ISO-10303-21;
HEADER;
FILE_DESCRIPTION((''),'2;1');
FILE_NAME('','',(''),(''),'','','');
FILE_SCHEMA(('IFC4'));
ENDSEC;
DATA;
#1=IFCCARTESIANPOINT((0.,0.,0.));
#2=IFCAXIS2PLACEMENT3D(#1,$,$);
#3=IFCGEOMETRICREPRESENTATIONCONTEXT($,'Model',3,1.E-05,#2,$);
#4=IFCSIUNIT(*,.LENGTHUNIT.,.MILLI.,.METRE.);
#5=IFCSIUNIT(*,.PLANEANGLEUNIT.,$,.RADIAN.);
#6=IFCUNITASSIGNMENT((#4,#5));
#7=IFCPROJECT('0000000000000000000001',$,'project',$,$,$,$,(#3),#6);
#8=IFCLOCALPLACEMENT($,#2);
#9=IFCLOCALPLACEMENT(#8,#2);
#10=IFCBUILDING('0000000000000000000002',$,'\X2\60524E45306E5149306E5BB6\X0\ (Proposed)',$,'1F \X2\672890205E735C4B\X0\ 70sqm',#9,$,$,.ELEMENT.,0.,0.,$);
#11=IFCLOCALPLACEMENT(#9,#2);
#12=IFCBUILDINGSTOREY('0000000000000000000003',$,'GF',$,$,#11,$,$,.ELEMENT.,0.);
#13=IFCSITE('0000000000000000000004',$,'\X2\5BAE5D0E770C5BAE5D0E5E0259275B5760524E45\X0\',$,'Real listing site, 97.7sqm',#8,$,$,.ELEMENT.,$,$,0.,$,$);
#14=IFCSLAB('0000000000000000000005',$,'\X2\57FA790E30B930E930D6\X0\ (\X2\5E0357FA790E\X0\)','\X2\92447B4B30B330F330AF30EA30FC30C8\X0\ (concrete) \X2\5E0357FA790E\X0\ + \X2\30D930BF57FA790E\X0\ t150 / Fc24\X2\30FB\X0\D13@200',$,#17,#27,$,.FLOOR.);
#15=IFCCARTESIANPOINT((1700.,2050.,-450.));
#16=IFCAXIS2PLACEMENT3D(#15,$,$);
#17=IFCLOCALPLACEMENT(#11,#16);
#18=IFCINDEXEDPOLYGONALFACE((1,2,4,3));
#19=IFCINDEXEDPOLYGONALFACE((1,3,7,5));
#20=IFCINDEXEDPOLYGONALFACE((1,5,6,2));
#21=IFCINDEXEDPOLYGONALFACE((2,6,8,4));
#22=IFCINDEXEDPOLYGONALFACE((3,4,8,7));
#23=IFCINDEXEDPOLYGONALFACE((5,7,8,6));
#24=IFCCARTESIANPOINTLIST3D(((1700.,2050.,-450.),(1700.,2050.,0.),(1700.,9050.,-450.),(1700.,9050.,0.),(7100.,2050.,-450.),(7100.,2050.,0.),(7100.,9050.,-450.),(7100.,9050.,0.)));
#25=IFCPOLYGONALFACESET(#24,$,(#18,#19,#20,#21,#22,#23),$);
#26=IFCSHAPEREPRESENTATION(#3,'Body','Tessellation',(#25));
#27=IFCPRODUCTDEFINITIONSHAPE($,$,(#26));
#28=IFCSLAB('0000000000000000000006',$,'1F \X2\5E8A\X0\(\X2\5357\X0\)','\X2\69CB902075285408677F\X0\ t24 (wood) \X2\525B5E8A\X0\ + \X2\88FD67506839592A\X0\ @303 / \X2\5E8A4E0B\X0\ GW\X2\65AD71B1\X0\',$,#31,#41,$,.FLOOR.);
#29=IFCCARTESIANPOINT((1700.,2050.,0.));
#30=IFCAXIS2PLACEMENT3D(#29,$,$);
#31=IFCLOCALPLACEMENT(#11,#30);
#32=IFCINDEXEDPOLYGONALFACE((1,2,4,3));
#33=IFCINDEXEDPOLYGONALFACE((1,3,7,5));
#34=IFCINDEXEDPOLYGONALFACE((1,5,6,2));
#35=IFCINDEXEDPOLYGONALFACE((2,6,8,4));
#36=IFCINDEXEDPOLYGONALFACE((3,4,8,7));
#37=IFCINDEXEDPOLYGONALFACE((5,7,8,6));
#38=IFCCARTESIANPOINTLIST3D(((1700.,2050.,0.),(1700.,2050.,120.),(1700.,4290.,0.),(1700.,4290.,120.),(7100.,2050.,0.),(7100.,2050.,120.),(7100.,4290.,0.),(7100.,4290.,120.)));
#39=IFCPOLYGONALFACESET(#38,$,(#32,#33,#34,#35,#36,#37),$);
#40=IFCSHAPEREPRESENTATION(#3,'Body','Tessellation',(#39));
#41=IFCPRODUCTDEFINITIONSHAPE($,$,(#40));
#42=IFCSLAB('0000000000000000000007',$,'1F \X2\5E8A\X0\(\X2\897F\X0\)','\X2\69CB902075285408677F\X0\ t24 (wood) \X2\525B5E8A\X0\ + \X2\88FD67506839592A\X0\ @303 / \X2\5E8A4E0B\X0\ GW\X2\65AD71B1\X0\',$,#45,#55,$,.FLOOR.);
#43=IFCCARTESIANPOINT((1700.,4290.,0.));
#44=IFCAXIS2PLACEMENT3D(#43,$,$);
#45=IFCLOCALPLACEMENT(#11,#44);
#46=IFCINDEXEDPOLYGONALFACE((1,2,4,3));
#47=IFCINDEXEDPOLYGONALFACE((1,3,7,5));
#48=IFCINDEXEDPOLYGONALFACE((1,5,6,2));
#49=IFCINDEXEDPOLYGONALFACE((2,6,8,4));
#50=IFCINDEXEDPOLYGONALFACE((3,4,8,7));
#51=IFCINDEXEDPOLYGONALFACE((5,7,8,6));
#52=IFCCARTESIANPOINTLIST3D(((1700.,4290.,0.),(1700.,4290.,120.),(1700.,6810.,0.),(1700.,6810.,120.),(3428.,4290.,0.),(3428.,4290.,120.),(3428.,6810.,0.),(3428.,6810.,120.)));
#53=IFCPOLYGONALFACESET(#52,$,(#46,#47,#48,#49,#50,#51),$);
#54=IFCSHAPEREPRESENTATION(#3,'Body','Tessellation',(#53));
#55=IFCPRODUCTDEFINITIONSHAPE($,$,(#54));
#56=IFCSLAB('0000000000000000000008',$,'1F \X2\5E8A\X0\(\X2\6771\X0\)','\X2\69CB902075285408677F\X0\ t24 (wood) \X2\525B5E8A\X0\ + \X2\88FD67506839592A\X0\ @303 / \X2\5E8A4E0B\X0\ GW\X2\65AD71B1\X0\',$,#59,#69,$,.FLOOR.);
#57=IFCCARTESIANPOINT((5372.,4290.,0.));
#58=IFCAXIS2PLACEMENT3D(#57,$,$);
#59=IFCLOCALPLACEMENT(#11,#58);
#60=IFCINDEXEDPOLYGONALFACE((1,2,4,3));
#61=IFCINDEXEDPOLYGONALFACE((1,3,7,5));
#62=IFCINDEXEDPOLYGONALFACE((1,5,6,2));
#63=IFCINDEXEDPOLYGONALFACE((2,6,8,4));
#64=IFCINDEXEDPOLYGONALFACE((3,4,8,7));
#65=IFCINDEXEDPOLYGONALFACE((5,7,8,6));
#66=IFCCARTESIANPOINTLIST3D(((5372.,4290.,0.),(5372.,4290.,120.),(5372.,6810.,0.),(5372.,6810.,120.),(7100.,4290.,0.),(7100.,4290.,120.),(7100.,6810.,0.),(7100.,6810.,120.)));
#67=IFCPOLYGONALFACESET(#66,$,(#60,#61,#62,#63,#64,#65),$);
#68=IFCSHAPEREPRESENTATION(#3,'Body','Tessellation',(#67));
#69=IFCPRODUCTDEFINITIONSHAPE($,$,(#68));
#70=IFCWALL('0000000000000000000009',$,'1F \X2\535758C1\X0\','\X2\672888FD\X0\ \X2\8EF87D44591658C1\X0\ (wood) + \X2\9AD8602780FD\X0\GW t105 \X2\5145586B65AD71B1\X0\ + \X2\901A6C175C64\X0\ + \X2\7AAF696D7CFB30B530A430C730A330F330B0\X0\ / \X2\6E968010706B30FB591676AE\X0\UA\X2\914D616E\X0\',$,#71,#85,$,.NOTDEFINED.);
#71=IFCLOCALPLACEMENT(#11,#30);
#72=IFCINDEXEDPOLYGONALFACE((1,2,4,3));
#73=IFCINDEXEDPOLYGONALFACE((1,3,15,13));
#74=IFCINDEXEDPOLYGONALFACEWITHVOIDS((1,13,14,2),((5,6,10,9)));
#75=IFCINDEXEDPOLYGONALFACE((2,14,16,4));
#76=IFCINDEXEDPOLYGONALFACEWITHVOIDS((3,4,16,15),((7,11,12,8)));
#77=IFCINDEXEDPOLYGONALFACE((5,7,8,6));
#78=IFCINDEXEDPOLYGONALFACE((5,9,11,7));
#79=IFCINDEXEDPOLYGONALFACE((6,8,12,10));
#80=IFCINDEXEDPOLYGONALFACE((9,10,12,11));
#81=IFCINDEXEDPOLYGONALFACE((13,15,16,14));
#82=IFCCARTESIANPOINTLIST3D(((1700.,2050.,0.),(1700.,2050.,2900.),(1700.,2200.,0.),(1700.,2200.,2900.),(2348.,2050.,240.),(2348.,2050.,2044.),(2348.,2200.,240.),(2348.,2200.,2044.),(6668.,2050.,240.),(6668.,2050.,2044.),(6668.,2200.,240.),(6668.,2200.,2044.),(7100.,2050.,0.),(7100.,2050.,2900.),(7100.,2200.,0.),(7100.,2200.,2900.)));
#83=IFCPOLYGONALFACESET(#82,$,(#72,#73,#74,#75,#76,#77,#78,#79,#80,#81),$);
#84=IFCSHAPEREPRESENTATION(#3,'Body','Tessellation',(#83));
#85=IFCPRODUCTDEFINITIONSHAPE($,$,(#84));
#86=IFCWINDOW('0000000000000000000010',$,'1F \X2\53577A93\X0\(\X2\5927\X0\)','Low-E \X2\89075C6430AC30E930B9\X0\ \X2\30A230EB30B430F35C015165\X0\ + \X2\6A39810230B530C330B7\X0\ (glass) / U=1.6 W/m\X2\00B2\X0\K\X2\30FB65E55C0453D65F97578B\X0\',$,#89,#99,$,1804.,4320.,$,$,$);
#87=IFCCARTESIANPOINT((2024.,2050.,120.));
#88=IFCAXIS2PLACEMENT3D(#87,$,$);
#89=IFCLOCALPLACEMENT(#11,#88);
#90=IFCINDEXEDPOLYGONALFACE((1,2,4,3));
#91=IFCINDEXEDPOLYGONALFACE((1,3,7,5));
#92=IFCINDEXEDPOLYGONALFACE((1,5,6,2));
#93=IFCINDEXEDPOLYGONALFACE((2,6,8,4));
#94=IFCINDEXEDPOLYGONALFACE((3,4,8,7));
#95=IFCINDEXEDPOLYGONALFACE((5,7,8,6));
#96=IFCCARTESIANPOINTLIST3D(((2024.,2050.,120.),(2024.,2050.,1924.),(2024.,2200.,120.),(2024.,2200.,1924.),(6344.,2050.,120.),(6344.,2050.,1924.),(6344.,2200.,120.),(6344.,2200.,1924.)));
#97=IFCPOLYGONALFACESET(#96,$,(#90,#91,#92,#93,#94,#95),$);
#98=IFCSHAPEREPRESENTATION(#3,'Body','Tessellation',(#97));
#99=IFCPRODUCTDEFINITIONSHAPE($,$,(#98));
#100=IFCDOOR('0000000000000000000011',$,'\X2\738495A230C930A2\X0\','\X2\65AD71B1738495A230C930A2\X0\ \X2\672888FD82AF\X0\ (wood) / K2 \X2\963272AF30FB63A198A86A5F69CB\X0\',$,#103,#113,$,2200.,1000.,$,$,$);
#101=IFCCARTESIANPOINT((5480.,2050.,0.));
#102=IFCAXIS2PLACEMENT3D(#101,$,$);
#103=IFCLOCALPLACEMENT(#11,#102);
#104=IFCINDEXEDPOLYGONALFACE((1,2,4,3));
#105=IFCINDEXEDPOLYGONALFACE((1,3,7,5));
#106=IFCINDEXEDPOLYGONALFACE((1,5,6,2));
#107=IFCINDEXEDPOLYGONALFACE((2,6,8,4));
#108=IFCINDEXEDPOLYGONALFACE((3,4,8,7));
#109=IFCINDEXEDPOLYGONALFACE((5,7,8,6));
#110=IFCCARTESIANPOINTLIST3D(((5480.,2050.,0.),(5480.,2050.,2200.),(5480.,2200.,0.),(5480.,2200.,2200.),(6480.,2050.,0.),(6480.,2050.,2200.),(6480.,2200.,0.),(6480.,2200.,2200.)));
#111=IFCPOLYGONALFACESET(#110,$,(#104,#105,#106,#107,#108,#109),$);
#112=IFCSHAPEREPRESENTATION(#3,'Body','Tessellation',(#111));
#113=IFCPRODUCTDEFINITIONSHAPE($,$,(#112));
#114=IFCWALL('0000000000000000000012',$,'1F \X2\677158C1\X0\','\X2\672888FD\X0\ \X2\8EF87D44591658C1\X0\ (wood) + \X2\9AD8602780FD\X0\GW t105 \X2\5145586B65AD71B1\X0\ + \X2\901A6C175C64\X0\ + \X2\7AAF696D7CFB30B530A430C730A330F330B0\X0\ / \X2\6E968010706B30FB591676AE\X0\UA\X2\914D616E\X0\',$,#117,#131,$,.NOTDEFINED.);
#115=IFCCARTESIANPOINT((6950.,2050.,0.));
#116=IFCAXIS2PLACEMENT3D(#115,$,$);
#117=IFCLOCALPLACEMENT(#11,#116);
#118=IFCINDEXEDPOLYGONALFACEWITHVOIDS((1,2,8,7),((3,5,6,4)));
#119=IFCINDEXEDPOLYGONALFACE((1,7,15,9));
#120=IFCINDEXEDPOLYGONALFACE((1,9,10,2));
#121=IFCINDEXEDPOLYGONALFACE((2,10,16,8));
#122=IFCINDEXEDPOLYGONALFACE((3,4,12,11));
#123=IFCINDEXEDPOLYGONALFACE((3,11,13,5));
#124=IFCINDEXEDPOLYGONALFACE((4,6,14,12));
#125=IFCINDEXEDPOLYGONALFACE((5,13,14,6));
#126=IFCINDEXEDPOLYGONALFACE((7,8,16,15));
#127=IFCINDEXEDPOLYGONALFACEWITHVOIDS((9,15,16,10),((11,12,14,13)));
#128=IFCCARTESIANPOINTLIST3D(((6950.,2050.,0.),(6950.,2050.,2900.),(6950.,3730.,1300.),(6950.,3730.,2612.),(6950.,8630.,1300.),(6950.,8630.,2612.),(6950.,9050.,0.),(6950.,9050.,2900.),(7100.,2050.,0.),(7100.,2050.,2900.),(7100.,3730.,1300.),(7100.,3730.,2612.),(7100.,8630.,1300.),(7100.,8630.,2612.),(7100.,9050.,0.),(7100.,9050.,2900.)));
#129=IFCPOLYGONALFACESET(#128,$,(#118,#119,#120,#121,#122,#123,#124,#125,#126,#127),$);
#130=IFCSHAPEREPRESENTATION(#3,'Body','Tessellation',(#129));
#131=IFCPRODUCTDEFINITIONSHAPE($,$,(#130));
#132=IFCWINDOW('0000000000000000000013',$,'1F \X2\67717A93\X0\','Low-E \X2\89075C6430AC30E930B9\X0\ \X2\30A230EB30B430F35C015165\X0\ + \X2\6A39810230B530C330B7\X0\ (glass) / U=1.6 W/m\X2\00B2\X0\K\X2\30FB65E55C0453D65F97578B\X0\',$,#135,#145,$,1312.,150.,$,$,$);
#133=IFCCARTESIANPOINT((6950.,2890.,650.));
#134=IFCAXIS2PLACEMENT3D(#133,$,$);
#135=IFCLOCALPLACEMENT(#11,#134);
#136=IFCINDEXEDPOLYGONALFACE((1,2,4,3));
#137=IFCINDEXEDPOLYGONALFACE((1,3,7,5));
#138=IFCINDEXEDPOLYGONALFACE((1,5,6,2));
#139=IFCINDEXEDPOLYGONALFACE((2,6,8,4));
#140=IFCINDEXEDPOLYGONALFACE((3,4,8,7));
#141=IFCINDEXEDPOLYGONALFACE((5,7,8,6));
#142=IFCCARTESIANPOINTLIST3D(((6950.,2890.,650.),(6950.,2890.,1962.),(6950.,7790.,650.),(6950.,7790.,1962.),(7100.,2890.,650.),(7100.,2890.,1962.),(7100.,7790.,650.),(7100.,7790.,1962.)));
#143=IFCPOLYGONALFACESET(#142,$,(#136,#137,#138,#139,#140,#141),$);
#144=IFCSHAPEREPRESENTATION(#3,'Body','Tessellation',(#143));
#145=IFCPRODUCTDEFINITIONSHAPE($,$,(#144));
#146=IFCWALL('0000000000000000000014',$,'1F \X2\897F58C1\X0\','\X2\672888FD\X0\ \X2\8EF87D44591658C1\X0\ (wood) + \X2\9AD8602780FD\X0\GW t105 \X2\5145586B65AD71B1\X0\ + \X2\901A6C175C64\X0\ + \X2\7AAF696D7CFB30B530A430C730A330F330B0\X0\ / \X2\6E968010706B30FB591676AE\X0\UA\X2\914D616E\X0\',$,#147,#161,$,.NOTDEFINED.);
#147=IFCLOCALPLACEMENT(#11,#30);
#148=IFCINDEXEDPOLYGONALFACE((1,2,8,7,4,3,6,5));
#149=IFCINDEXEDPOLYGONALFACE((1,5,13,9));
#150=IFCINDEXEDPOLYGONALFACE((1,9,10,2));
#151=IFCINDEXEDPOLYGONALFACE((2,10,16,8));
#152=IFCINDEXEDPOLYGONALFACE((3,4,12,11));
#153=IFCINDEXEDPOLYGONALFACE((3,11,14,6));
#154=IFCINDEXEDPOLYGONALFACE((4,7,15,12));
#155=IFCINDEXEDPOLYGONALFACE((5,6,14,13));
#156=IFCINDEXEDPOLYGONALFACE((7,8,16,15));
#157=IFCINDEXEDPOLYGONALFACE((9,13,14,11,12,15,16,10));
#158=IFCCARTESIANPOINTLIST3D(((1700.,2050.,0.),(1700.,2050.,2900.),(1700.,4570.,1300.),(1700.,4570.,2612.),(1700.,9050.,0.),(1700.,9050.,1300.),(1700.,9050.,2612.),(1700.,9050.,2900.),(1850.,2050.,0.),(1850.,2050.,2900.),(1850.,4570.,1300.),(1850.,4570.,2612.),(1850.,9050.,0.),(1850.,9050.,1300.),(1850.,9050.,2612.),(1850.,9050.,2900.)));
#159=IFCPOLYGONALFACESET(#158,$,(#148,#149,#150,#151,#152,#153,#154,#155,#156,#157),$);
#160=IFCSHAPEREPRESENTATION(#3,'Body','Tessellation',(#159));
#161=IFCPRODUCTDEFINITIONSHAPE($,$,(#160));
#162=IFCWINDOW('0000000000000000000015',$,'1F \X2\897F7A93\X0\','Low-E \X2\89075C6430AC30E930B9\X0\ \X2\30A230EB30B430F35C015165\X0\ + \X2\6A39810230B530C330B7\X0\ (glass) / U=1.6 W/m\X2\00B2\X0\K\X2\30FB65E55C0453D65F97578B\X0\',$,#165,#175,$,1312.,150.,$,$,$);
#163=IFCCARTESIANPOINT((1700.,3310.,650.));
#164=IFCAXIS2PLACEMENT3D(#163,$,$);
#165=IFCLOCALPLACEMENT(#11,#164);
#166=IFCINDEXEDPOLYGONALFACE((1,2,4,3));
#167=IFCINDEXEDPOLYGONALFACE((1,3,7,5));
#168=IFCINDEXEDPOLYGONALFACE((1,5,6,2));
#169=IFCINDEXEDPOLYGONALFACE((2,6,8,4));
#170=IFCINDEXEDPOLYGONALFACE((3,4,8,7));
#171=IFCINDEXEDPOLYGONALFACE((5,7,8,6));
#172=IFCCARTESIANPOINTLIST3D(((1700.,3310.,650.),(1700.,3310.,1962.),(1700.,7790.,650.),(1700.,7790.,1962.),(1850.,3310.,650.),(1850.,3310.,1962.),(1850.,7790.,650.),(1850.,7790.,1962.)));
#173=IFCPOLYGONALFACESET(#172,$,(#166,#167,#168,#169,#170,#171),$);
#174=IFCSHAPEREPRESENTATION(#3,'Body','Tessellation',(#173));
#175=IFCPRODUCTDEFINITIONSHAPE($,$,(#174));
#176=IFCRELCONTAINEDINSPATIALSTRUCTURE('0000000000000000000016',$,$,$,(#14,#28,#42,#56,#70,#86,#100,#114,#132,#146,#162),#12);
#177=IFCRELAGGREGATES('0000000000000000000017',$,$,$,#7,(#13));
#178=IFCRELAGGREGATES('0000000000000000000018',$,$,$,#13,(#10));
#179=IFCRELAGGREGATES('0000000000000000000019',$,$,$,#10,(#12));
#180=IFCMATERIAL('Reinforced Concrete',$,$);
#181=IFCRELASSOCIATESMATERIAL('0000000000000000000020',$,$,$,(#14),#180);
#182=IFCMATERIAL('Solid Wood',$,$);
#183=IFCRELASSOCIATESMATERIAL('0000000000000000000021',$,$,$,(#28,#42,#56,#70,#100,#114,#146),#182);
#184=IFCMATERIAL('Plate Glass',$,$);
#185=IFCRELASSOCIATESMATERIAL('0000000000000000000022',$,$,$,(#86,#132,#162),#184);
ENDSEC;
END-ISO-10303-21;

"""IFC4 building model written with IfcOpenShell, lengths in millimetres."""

from ifc_helpers import new_model, si_unit, frame, frame_2d, origin, place, context, project, spatial, rectangle, extrude, material, element, fill, save


model = new_model("IFC4")

# Units and contexts
model_context = context("Model", 3, precision=1e-05, world=origin())
ifc_project = project(units=[si_unit("LENGTHUNIT", "METRE", prefix="MILLI"), si_unit("PLANEANGLEUNIT", "RADIAN")], contexts=[model_context])

# Site, building, storey
site_placement = place(None, origin())
site = spatial("IfcSite", under=ifc_project, at=site_placement, Name="宮崎県宮崎市大字恒久", ObjectType="Real listing site, 97.7sqm", CompositionType="ELEMENT", RefElevation=0.0)
building_placement = place(site_placement, origin())
building = spatial("IfcBuilding", under=site, at=building_placement, Name="恒久の光の家 (Proposed)", ObjectType="1F 木造平屋 70sqm", CompositionType="ELEMENT", ElevationOfRefHeight=0.0, ElevationOfTerrain=0.0)
storey_placement = place(building_placement, origin())
storey = spatial("IfcBuildingStorey", under=building, at=storey_placement, Name="GF", CompositionType="ELEMENT", Elevation=0.0)

# Slabs
ifc_material_1 = material(Name="Reinforced Concrete")
slab_1_placement = place(storey_placement, frame((1700.0, 2050.0, -450.0)))
element("IfcSlab", 1, at=slab_1_placement, inside=storey, material=ifc_material_1, Name="基礎スラブ (布基礎)", Description="鉄筋コンクリート (concrete) 布基礎 + ベタ基礎 t150 / Fc24・D13@200", PredefinedType="FLOOR", context=model_context, shape_type="SweptSolid", body=[
    extrude(rectangle(XDim=5400.0, YDim=7000.0, at=frame_2d((2700.0, 3500.0))), frame((1700.0, 2050.0, -450.0)), (0.0, 0.0, 1.0), 450.0),
])
ifc_material_2 = material(Name="Solid Wood")
slab_2_placement = place(storey_placement, frame((1700.0, 2050.0, 0.0)))
element("IfcSlab", 2, at=slab_2_placement, inside=storey, material=ifc_material_2, Name="1F 床(南)", Description="構造用合板 t24 (wood) 剛床 + 製材根太 @303 / 床下 GW断熱", PredefinedType="FLOOR", context=model_context, shape_type="SweptSolid", body=[
    extrude(rectangle(XDim=5400.0, YDim=2240.0, at=frame_2d((2700.0, 1120.0))), frame((1700.0, 2050.0, 0.0)), (0.0, 0.0, 1.0), 120.0),
])
slab_3_placement = place(storey_placement, frame((1700.0, 4290.0, 0.0)))
element("IfcSlab", 3, at=slab_3_placement, inside=storey, material=ifc_material_2, Name="1F 床(西)", Description="構造用合板 t24 (wood) 剛床 + 製材根太 @303 / 床下 GW断熱", PredefinedType="FLOOR", context=model_context, shape_type="SweptSolid", body=[
    extrude(rectangle(XDim=1728.0, YDim=2520.0, at=frame_2d((864.0, 1260.0))), frame((1700.0, 4290.0, 0.0)), (0.0, 0.0, 1.0), 120.0),
])
slab_4_placement = place(storey_placement, frame((5372.0, 4290.0, 0.0)))
element("IfcSlab", 4, at=slab_4_placement, inside=storey, material=ifc_material_2, Name="1F 床(東)", Description="構造用合板 t24 (wood) 剛床 + 製材根太 @303 / 床下 GW断熱", PredefinedType="FLOOR", context=model_context, shape_type="SweptSolid", body=[
    extrude(rectangle(XDim=1728.0, YDim=2520.0, at=frame_2d((864.0, 1260.0))), frame((5372.0, 4290.0, 0.0)), (0.0, 0.0, 1.0), 120.0),
])

# Wall, openings, window, door
wall_1_placement = place(storey_placement, frame((1700.0, 2050.0, 0.0)))
wall_1 = element("IfcWall", 5, at=wall_1_placement, inside=storey, material=ifc_material_2, Name="1F 南壁", Description="木製 軸組外壁 (wood) + 高性能GW t105 充填断熱 + 通気層 + 窯業系サイディング / 準耐火・外皮UA配慮", PredefinedType="NOTDEFINED", context=model_context, shape_type="SweptSolid", body=[
    extrude(rectangle(XDim=5400.0, YDim=150.0, at=frame_2d((2700.0, 75.0))), frame((1700.0, 2050.0, 0.0)), (0.0, 0.0, 1.0), 2900.0),
])
opening_1_placement = place(storey_placement, frame((2024.0, 2050.0, 120.0)))
opening_1 = element("IfcOpeningElement", 6, at=opening_1_placement, cuts=wall_1, PredefinedType="NOTDEFINED", context=model_context, shape_type="SweptSolid", body=[
    extrude(rectangle(XDim=4320.0, YDim=150.0, at=frame_2d((2160.0, 75.0))), frame((2024.0, 2050.0, 120.0)), (0.0, 0.0, 1.0), 1804.0),
])
opening_2_placement = place(storey_placement, frame((5480.0, 2050.0, 0.0)))
opening_2 = element("IfcOpeningElement", 7, at=opening_2_placement, cuts=wall_1, PredefinedType="NOTDEFINED", context=model_context, shape_type="SweptSolid", body=[
    extrude(rectangle(XDim=1000.0, YDim=150.0, at=frame_2d((500.0, 75.0))), frame((5480.0, 2050.0, 0.0)), (0.0, 0.0, 1.0), 2200.0),
])
ifc_material_3 = material(Name="Plate Glass")
window_1_placement = place(storey_placement, frame((2024.0, 2050.0, 120.0)))
window_1 = element("IfcWindow", 8, at=window_1_placement, inside=storey, material=ifc_material_3, Name="1F 南窓(大)", Description="Low-E 複層ガラス アルゴン封入 + 樹脂サッシ (glass) / U=1.6 W/m²K・日射取得型", OverallHeight=1804.0, OverallWidth=4320.0, context=model_context, shape_type="SweptSolid", body=[
    extrude(rectangle(XDim=4320.0, YDim=150.0, at=frame_2d((2160.0, 75.0))), frame((2024.0, 2050.0, 120.0)), (0.0, 0.0, 1.0), 1804.0),
])
fill(opening_1, window_1)
door_placement = place(storey_placement, frame((5480.0, 2050.0, 0.0)))
door = element("IfcDoor", 9, at=door_placement, inside=storey, material=ifc_material_2, Name="玄関ドア", Description="断熱玄関ドア 木製芯 (wood) / K2 防犯・採風機構", OverallHeight=2200.0, OverallWidth=1000.0, context=model_context, shape_type="SweptSolid", body=[
    extrude(rectangle(XDim=1000.0, YDim=150.0, at=frame_2d((500.0, 75.0))), frame((5480.0, 2050.0, 0.0)), (0.0, 0.0, 1.0), 2200.0),
])
fill(opening_2, door)

# Walls, openings, windows
wall_2_placement = place(storey_placement, frame((6950.0, 2050.0, 0.0)))
wall_2 = element("IfcWall", 10, at=wall_2_placement, inside=storey, material=ifc_material_2, Name="1F 東壁", Description="木製 軸組外壁 (wood) + 高性能GW t105 充填断熱 + 通気層 + 窯業系サイディング / 準耐火・外皮UA配慮", PredefinedType="NOTDEFINED", context=model_context, shape_type="SweptSolid", body=[
    extrude(rectangle(XDim=150.0, YDim=7000.0, at=frame_2d((75.0, 3500.0))), frame((6950.0, 2050.0, 0.0)), (0.0, 0.0, 1.0), 2900.0),
])
opening_3_placement = place(storey_placement, frame((6950.0, 2890.0, 650.0)))
opening_3 = element("IfcOpeningElement", 11, at=opening_3_placement, cuts=wall_2, PredefinedType="NOTDEFINED", context=model_context, shape_type="SweptSolid", body=[
    extrude(rectangle(XDim=150.0, YDim=4900.0, at=frame_2d((75.0, 2450.0))), frame((6950.0, 2890.0, 650.0)), (0.0, 0.0, 1.0), 1312.0),
])
window_2_placement = place(storey_placement, frame((6950.0, 2890.0, 650.0)))
window_2 = element("IfcWindow", 12, at=window_2_placement, inside=storey, material=ifc_material_3, Name="1F 東窓", Description="Low-E 複層ガラス アルゴン封入 + 樹脂サッシ (glass) / U=1.6 W/m²K・日射取得型", OverallHeight=1312.0, OverallWidth=150.0, context=model_context, shape_type="SweptSolid", body=[
    extrude(rectangle(XDim=150.0, YDim=4900.0, at=frame_2d((75.0, 2450.0))), frame((6950.0, 2890.0, 650.0)), (0.0, 0.0, 1.0), 1312.0),
])
fill(opening_3, window_2)
wall_3_placement = place(storey_placement, frame((1700.0, 2050.0, 0.0)))
wall_3 = element("IfcWall", 13, at=wall_3_placement, inside=storey, material=ifc_material_2, Name="1F 西壁", Description="木製 軸組外壁 (wood) + 高性能GW t105 充填断熱 + 通気層 + 窯業系サイディング / 準耐火・外皮UA配慮", PredefinedType="NOTDEFINED", context=model_context, shape_type="SweptSolid", body=[
    extrude(rectangle(XDim=150.0, YDim=7000.0, at=frame_2d((75.0, 3500.0))), frame((1700.0, 2050.0, 0.0)), (0.0, 0.0, 1.0), 2900.0),
])
opening_4_placement = place(storey_placement, frame((1700.0, 3310.0, 650.0)))
opening_4 = element("IfcOpeningElement", 14, at=opening_4_placement, cuts=wall_3, PredefinedType="NOTDEFINED", context=model_context, shape_type="SweptSolid", body=[
    extrude(rectangle(XDim=150.0, YDim=4480.0, at=frame_2d((75.0, 2240.0))), frame((1700.0, 3310.0, 650.0)), (0.0, 0.0, 1.0), 1312.0),
])
window_3_placement = place(storey_placement, frame((1700.0, 3310.0, 650.0)))
window_3 = element("IfcWindow", 15, at=window_3_placement, inside=storey, material=ifc_material_3, Name="1F 西窓", Description="Low-E 複層ガラス アルゴン封入 + 樹脂サッシ (glass) / U=1.6 W/m²K・日射取得型", OverallHeight=1312.0, OverallWidth=150.0, context=model_context, shape_type="SweptSolid", body=[
    extrude(rectangle(XDim=150.0, YDim=4480.0, at=frame_2d((75.0, 2240.0))), frame((1700.0, 3310.0, 650.0)), (0.0, 0.0, 1.0), 1312.0),
])
fill(opening_4, window_3)

save(model, "model.ifc")
